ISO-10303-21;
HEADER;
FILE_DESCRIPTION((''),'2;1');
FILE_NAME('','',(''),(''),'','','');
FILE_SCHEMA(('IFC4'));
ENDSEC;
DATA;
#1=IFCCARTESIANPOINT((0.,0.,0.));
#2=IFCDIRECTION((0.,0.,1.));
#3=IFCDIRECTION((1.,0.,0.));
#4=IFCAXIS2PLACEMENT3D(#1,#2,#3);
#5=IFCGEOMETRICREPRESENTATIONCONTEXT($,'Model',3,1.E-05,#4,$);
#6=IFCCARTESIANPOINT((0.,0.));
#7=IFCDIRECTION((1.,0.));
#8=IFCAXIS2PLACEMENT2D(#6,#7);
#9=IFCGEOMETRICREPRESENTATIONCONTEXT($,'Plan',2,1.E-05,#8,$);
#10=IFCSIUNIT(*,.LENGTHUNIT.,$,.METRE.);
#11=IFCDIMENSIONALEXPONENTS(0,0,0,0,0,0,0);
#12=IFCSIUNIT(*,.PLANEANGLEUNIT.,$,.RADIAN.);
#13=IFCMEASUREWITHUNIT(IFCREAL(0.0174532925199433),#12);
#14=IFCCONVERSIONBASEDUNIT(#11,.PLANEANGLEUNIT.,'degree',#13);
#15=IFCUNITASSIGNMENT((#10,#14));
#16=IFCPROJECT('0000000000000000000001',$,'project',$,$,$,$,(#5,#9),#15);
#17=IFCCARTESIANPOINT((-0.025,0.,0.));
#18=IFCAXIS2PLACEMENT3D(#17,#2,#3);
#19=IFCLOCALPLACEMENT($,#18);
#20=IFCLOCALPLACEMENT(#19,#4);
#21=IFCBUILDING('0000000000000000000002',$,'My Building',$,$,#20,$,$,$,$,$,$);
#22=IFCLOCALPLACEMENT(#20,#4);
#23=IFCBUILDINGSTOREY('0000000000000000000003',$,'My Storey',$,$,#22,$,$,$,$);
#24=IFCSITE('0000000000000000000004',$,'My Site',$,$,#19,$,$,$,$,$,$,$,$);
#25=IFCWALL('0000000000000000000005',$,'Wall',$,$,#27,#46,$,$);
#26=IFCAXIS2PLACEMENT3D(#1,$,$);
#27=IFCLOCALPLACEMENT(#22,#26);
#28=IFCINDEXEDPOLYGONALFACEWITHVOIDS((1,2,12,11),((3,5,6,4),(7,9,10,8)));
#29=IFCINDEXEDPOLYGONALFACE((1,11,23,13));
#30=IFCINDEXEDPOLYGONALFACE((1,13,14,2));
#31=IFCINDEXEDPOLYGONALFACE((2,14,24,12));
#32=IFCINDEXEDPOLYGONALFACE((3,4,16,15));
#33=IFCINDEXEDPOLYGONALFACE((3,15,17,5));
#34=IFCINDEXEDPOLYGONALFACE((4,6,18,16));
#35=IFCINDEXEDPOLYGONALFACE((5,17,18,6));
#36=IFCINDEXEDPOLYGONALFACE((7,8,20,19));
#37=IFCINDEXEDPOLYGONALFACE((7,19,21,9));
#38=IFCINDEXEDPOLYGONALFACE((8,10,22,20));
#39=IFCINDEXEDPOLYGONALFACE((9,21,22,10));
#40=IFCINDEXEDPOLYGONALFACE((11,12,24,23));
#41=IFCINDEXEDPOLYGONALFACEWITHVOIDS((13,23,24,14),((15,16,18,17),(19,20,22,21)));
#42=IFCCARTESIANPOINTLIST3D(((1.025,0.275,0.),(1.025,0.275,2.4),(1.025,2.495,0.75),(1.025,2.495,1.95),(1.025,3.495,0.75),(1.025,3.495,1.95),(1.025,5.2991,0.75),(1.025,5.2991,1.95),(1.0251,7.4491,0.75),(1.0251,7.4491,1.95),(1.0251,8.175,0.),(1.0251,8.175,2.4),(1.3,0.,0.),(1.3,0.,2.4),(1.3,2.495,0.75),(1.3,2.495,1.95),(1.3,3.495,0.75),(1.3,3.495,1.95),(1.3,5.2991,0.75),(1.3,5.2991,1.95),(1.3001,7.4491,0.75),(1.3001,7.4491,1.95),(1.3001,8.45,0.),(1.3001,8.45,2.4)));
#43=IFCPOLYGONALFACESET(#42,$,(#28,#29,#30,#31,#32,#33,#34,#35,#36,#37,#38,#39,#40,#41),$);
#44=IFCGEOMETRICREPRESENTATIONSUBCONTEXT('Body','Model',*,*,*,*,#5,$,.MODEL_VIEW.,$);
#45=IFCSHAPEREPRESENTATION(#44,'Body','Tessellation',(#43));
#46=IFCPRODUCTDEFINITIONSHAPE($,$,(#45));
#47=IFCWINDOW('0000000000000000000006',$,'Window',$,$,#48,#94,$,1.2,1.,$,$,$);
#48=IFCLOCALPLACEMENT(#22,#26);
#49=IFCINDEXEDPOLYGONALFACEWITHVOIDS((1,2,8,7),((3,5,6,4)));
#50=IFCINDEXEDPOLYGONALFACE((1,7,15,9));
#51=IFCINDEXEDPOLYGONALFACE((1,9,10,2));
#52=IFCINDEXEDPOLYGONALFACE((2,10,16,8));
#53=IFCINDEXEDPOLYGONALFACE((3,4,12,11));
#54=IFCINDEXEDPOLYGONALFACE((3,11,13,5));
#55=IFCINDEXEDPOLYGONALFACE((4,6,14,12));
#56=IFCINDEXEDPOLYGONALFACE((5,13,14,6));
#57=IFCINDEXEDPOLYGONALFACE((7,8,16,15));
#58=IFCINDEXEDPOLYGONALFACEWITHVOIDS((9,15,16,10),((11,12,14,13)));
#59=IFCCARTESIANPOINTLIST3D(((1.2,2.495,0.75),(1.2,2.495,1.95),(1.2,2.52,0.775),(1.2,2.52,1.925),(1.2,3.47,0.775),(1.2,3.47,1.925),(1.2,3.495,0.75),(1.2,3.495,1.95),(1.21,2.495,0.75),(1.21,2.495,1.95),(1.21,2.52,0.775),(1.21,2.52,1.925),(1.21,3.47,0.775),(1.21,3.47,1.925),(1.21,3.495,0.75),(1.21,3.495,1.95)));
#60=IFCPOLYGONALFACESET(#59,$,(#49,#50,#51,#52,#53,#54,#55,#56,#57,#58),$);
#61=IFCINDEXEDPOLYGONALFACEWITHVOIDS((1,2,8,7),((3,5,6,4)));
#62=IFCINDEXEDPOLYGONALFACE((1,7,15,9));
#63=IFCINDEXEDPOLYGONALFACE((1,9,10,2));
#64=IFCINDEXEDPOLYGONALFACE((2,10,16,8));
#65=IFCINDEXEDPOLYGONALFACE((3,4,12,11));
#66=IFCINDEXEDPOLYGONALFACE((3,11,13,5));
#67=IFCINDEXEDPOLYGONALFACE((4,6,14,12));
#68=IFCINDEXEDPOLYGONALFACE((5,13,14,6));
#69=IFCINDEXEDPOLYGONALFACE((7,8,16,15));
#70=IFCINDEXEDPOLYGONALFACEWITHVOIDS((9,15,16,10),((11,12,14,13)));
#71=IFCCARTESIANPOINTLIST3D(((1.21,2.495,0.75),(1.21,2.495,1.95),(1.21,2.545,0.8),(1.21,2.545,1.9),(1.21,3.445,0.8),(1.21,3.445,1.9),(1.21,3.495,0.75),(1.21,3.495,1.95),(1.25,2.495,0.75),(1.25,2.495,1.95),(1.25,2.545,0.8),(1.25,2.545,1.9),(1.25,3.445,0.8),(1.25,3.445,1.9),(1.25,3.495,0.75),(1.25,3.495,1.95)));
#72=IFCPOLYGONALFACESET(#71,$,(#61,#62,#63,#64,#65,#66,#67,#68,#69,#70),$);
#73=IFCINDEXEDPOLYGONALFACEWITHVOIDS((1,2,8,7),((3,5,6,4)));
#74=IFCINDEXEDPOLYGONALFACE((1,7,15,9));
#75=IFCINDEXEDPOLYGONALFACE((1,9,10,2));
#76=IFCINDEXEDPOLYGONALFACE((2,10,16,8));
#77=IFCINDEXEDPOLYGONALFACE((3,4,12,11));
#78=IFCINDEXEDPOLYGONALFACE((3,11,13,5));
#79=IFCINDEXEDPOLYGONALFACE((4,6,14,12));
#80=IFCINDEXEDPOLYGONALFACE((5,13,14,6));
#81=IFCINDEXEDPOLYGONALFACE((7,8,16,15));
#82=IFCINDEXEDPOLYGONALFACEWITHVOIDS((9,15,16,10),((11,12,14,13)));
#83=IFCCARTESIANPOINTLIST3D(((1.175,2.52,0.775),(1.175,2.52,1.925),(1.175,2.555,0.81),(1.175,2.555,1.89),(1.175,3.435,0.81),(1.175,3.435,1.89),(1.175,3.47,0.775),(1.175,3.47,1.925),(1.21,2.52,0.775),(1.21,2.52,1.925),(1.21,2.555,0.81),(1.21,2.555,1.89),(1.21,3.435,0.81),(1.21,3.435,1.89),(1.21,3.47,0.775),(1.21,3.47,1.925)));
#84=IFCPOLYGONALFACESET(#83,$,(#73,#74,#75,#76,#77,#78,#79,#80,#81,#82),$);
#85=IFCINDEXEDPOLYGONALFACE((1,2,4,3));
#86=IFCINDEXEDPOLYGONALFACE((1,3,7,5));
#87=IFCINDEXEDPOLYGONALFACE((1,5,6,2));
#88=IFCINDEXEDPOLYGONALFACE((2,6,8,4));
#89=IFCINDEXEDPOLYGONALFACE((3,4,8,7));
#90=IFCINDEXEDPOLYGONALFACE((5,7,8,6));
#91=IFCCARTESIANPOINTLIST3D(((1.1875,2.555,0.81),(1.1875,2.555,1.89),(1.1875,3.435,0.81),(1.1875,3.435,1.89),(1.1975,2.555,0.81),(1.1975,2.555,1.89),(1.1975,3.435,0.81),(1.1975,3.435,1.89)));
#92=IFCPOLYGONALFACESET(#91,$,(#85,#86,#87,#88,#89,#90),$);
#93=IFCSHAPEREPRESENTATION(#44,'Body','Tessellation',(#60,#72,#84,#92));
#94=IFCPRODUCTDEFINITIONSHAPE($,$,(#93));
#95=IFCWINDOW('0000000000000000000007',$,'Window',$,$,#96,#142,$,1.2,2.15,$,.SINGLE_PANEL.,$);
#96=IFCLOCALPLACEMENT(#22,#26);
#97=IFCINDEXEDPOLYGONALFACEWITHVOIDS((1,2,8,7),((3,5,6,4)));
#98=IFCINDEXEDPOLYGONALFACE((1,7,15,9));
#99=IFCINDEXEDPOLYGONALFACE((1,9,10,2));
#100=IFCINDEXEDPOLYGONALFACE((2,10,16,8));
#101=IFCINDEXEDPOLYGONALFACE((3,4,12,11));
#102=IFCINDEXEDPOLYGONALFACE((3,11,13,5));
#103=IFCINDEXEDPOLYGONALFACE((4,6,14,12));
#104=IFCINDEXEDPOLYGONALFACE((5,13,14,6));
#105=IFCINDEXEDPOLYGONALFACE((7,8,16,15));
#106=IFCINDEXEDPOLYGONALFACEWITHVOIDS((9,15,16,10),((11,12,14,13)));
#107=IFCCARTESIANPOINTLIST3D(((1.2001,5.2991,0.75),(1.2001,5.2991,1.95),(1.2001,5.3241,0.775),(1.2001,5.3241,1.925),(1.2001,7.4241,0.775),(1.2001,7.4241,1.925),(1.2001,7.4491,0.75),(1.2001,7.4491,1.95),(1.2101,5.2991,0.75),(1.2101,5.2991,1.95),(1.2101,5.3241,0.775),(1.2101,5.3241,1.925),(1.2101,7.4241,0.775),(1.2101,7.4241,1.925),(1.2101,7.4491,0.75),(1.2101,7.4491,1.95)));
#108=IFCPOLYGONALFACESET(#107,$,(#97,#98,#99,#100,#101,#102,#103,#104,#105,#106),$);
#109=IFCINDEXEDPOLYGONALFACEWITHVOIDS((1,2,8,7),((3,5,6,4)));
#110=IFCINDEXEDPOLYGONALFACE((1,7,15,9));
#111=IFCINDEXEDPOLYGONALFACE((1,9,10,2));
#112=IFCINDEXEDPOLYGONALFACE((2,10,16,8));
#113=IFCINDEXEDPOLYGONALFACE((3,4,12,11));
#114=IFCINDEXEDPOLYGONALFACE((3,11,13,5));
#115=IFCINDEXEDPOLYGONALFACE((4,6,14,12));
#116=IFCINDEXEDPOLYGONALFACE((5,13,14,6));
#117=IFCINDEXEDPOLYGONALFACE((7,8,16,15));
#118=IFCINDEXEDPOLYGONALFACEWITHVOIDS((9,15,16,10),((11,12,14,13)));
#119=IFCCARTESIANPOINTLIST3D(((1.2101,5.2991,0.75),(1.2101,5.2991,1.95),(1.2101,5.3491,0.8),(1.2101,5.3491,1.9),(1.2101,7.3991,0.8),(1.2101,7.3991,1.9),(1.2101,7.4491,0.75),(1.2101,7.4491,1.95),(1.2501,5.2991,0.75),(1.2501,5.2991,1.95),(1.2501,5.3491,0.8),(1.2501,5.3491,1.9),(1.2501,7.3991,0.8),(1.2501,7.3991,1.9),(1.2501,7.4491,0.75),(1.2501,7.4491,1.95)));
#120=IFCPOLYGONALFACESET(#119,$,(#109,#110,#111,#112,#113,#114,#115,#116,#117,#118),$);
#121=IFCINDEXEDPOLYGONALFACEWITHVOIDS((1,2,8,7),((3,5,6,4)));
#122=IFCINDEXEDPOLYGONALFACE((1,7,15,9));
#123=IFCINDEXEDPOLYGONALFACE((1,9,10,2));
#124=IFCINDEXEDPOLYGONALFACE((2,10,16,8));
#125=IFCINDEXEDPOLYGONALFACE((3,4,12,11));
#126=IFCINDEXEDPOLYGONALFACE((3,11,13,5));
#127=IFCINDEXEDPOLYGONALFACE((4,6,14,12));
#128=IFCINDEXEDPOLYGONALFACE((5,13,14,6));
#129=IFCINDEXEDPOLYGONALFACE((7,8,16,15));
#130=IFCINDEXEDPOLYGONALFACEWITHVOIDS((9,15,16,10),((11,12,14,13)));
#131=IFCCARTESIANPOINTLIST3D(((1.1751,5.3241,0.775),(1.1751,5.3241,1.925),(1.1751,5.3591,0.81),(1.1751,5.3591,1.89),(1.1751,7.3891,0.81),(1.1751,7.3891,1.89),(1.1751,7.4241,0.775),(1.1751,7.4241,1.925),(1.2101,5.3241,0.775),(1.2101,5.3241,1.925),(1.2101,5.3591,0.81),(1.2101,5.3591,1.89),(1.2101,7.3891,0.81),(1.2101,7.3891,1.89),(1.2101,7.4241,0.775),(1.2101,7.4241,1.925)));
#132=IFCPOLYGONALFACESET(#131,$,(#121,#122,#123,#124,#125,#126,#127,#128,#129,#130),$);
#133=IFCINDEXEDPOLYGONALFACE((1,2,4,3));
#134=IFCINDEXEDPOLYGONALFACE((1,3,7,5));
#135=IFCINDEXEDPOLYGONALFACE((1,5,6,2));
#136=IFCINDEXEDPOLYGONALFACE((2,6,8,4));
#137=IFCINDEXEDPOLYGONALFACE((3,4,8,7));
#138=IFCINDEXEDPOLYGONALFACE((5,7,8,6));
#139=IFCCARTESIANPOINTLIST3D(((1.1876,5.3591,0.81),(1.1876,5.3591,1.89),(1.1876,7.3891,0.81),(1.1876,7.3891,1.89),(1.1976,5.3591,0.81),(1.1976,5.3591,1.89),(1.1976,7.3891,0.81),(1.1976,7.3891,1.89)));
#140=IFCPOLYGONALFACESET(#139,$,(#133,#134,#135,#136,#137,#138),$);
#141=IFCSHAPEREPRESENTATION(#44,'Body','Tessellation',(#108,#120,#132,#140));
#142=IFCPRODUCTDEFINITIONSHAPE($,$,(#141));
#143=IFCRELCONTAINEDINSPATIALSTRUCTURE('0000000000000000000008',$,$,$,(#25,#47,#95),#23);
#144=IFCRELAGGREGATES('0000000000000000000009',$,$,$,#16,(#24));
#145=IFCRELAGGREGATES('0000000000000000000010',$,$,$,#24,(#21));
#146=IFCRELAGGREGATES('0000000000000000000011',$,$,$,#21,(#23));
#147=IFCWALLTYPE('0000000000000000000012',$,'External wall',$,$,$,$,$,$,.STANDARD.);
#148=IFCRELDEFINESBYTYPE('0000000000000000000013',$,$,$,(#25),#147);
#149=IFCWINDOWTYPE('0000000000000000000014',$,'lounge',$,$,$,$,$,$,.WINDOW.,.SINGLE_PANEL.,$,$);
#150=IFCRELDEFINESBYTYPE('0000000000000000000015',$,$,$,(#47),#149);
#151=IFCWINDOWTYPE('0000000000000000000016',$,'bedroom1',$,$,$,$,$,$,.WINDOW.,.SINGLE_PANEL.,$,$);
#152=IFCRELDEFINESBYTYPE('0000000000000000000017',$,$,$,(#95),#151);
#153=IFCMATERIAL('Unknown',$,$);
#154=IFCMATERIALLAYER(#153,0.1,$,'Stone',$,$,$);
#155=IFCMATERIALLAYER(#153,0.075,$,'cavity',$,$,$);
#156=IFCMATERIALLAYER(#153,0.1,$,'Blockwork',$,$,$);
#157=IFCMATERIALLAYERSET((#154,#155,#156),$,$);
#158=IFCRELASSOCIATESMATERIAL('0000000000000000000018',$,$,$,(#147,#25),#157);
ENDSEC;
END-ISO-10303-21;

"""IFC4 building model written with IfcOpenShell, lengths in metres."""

from ifc_helpers import new_model, entity, si_unit, converted_unit, frame, origin_with_axes, origin_2d_with_axis, place, context, subcontext, project, spatial, line, indexed_curve, outline, extrude, clip, halfspace, shape, source, transform, mapped, material, layer, layer_set, layer_usage, type_object, type_shapes, element, fill, save


model = new_model("IFC4")

# Units and contexts
model_context = context("Model", 3, precision=1e-05, world=origin_with_axes())
plan_context = context("Plan", 2, precision=1e-05, world=origin_2d_with_axis())
body_context_1 = subcontext(model_context, "Body", "Model", "MODEL_VIEW")
body_context_2 = subcontext(plan_context, "Body", "Plan", "PLAN_VIEW")
ifc_project = project(units=[si_unit("LENGTHUNIT", "METRE"), converted_unit("PLANEANGLEUNIT", "degree", entity("IfcReal", 0.0174532925199433), si_unit("PLANEANGLEUNIT", "RADIAN"), dimensions=[0, 0, 0, 0, 0, 0, 0])], contexts=[model_context, plan_context])

# Site, building, storey
site_placement = place(None, frame((-0.025, 0.0, 0.0), z_axis=(0.0, 0.0, 1.0), x_axis=(1.0, 0.0, 0.0)))
site = spatial("IfcSite", under=ifc_project, at=site_placement, Name="My Site")
building_placement = place(site_placement, origin_with_axes())
building = spatial("IfcBuilding", under=site, at=building_placement, Name="My Building")
storey_placement = place(building_placement, origin_with_axes())
storey = spatial("IfcBuildingStorey", under=building, at=storey_placement, Name="My Storey")

# Shared definitions
ifc_material = material(Name="Unknown")
ifc_layer_1 = layer(ifc_material, 0.1, Name="Stone")
ifc_layer_2 = layer(ifc_material, 0.075, Name="cavity")
ifc_layer_3 = layer(ifc_material, 0.1, Name="Blockwork")
ifc_layer_set_1 = layer_set([ifc_layer_1, ifc_layer_2, ifc_layer_3])
wall_type_1 = type_object("IfcWallType", Name="External wall", PredefinedType="STANDARD", material=ifc_layer_set_1)

# Wall, openings, windows
ifc_layer_usage_1 = layer_usage(ifc_layer_set_1, "AXIS2", "POSITIVE", 0.0)
wall_1_placement = place(storey_placement, frame((1.3, 0.0, 0.0), z_axis=(0.0, 0.0, 1.0), x_axis=(0.0, 1.0, 0.0)))
wall_1 = element("IfcWall", 1, at=wall_1_placement, inside=storey, type_object=wall_type_1, material=ifc_layer_usage_1, Name="Wall", context=body_context_1, shape_type="Clipping", body=[
    clip(clip(extrude(outline(indexed_curve([(0.0, 0.0), (0.0, 0.275), (8.45, 0.275), (8.45, 0.0), (0.0, 0.0)], self_intersect=False)), origin_with_axes(), (0.0, 0.0, 1.0), 2.4), halfspace(frame((0.0, 0.0, 0.0), z_axis=(-0.707107, 0.707107, 0.0), x_axis=(0.707107, 0.707107, 0.0)), False)), halfspace(frame((8.45, 0.0, 0.0), z_axis=(0.707107, 0.707106, 0.0), x_axis=(-0.707106, 0.707107, 0.0)), False)),
])
shared_shape_1 = source(origin_with_axes(), body_context_1, "Body", "SweptSolid", [
    extrude(outline(indexed_curve([(0.0, 0.0), (1.0, 0.0), (1.0, 1.2), (0.0, 1.2)], segments=[line(1, 2, 3, 4, 1)])), frame((0.0, -0.6, 0.0), z_axis=(0.0, -1.0, 0.0), x_axis=(1.0, 0.0, 0.0)), (0.0, 0.0, -1.0), 1.2),
])
opening_1_placement = place(wall_1_placement, frame((2.495, 0.0, 0.75), z_axis=(0.0, 0.0, 1.0), x_axis=(1.0, 0.0, 0.0)))
opening_1 = element("IfcOpeningElement", 2, at=opening_1_placement, cuts=wall_1, PredefinedType="OPENING", context=body_context_1, shape_type="MappedRepresentation", body=[
    mapped(shared_shape_1, transform((0.0, 0.0, 0.0), x_axis=(1.0, 0.0, 0.0), y_axis=(0.0, 1.0, 0.0), z_axis=(0.0, 0.0, 1.0), scale=1.0)),
])
shared_shape_2 = source(origin_with_axes(), body_context_1, "Body", "SweptSolid", [
    extrude(outline(indexed_curve([(0.0, 0.0), (2.15, 0.0), (2.15, 1.2), (0.0, 1.2)], segments=[line(1, 2, 3, 4, 1)])), frame((0.0, -0.1, 0.0), z_axis=(0.0, -1.0, 0.0), x_axis=(1.0, 0.0, 0.0)), (0.0, 0.0, -1.0), 0.475),
])
opening_2_placement = place(wall_1_placement, frame((5.2991, 0.0, 0.75), z_axis=(0.0, 0.0, 1.0), x_axis=(1.0, 0.0, 0.0)))
opening_2 = element("IfcOpeningElement", 3, at=opening_2_placement, cuts=wall_1, PredefinedType="OPENING", context=body_context_1, shape_type="MappedRepresentation", body=[
    mapped(shared_shape_2, transform((0.0, 0.0, 0.0), x_axis=(1.0, 0.0, 0.0), y_axis=(0.0, 1.0, 0.0), z_axis=(0.0, 0.0, 1.0), scale=1.0)),
])
window_type_1 = type_object("IfcWindowType", Name="lounge", PartitioningType="SINGLE_PANEL", PredefinedType="WINDOW")
shared_shape_3 = source(origin_with_axes(), body_context_1, "Body", "SweptSolid", [
    extrude(outline(indexed_curve([(0.0, 0.0), (1.0, 0.0), (1.0, 1.2), (0.0, 1.2)], segments=[line(1, 2, 3, 4, 1)]), holes=[indexed_curve([(0.025, 0.025), (0.975, 0.025), (0.975, 1.175), (0.025, 1.175)], segments=[line(1, 2, 3, 4, 1)])]), frame((0.0, 0.09, 0.0), z_axis=(0.0, -1.0, 0.0), x_axis=(1.0, 0.0, 0.0)), (0.0, 0.0, -1.0), 0.01),
    extrude(outline(indexed_curve([(0.0, 0.0), (1.0, 0.0), (1.0, 1.2), (0.0, 1.2)], segments=[line(1, 2, 3, 4, 1)]), holes=[indexed_curve([(0.05, 0.05), (0.95, 0.05), (0.95, 1.15), (0.05, 1.15)], segments=[line(1, 2, 3, 4, 1)])]), frame((0.0, 0.05, 0.0), z_axis=(0.0, -1.0, 0.0), x_axis=(1.0, 0.0, 0.0)), (0.0, 0.0, -1.0), 0.04),
    extrude(outline(indexed_curve([(0.0, 0.0), (0.95, 0.0), (0.95, 1.15), (0.0, 1.15)], segments=[line(1, 2, 3, 4, 1)]), holes=[indexed_curve([(0.035, 0.035), (0.915, 0.035), (0.915, 1.115), (0.035, 1.115)], segments=[line(1, 2, 3, 4, 1)])]), frame((0.025, 0.09, 0.025), z_axis=(0.0, -1.0, 0.0), x_axis=(1.0, 0.0, 0.0)), (0.0, 0.0, -1.0), 0.035),
    extrude(outline(indexed_curve([(0.035, 0.035), (0.915, 0.035), (0.915, 1.115), (0.035, 1.115)], segments=[line(1, 2, 3, 4, 1)])), frame((0.025, 0.1025, 0.025), z_axis=(0.0, -1.0, 0.0), x_axis=(1.0, 0.0, 0.0)), (0.0, 0.0, -1.0), 0.01),
])
shared_shape_4 = source(origin_with_axes(), body_context_2, "Body", "Curve2D", [
    entity("IfcIndexedPolyCurve", entity("IfcCartesianPointList2D", [[0.05, 0.05], [0.95, 0.05]])),
    entity("IfcIndexedPolyCurve", entity("IfcCartesianPointList2D", [[0.0, 0.1], [0.025, 0.1], [0.025, 0.09], [0.05, 0.09], [0.05, 0.05], [0.0, 0.05]]), [entity("IfcLineIndex", [1, 2, 3, 4, 5, 6, 1])]),
    entity("IfcIndexedPolyCurve", entity("IfcCartesianPointList2D", [[1.0, 0.1], [0.975, 0.1], [0.975, 0.09], [0.95, 0.09], [0.95, 0.05], [1.0, 0.05]]), [entity("IfcLineIndex", [1, 2, 3, 4, 5, 6, 1])]),
    entity("IfcIndexedPolyCurve", entity("IfcCartesianPointList2D", [[0.025, 0.09], [0.06, 0.09], [0.06, 0.125], [0.025, 0.125]]), [entity("IfcLineIndex", [1, 2, 3, 4, 1])]),
    entity("IfcIndexedPolyCurve", entity("IfcCartesianPointList2D", [[0.975, 0.09], [0.94, 0.09], [0.94, 0.125], [0.975, 0.125]]), [entity("IfcLineIndex", [1, 2, 3, 4, 1])]),
    entity("IfcIndexedPolyCurve", entity("IfcCartesianPointList2D", [[0.06, 0.09], [0.94, 0.09]])),
    entity("IfcIndexedPolyCurve", entity("IfcCartesianPointList2D", [[0.06, 0.125], [0.94, 0.125]])),
    entity("IfcIndexedPolyCurve", entity("IfcCartesianPointList2D", [[0.06, 0.1075], [0.94, 0.1075]])),
])
type_shapes(window_type_1, [shared_shape_3, shared_shape_4])
window_1_placement = place(opening_1_placement, frame((0.0, 0.0, 0.0), z_axis=(0.0, 0.0, 1.0), x_axis=(1.0, 0.0, 0.0)))
window_1 = element("IfcWindow", 4, at=window_1_placement, inside=storey, type_object=window_type_1, Name="Window", OverallHeight=1.2, OverallWidth=1.0, shapes=[
    shape(body_context_1, "Body", "MappedRepresentation", [mapped(shared_shape_3, transform((0.0, 0.0, 0.0), x_axis=(1.0, 0.0, 0.0), y_axis=(0.0, 1.0, 0.0), z_axis=(0.0, 0.0, 1.0), scale=1.0))]),
    shape(body_context_2, "Body", "MappedRepresentation", [mapped(shared_shape_4, transform((0.0, 0.0, 0.0), x_axis=(1.0, 0.0, 0.0), y_axis=(0.0, 1.0, 0.0), z_axis=(0.0, 0.0, 1.0), scale=1.0))]),
])
fill(opening_1, window_1)
window_type_2 = type_object("IfcWindowType", Name="bedroom1", PartitioningType="SINGLE_PANEL", PredefinedType="WINDOW")
shared_shape_5 = source(origin_with_axes(), body_context_1, "Body", "SweptSolid", [
    extrude(outline(indexed_curve([(0.0, 0.0), (2.15, 0.0), (2.15, 1.2), (0.0, 1.2)], segments=[line(1, 2, 3, 4, 1)]), holes=[indexed_curve([(0.025, 0.025), (2.125, 0.025), (2.125, 1.175), (0.025, 1.175)], segments=[line(1, 2, 3, 4, 1)])]), frame((0.0, 0.09, 0.0), z_axis=(0.0, -1.0, 0.0), x_axis=(1.0, 0.0, 0.0)), (0.0, 0.0, -1.0), 0.01),
    extrude(outline(indexed_curve([(0.0, 0.0), (2.15, 0.0), (2.15, 1.2), (0.0, 1.2)], segments=[line(1, 2, 3, 4, 1)]), holes=[indexed_curve([(0.05, 0.05), (2.1, 0.05), (2.1, 1.15), (0.05, 1.15)], segments=[line(1, 2, 3, 4, 1)])]), frame((0.0, 0.05, 0.0), z_axis=(0.0, -1.0, 0.0), x_axis=(1.0, 0.0, 0.0)), (0.0, 0.0, -1.0), 0.04),
    extrude(outline(indexed_curve([(0.0, 0.0), (2.1, 0.0), (2.1, 1.15), (0.0, 1.15)], segments=[line(1, 2, 3, 4, 1)]), holes=[indexed_curve([(0.035, 0.035), (2.065, 0.035), (2.065, 1.115), (0.035, 1.115)], segments=[line(1, 2, 3, 4, 1)])]), frame((0.025, 0.09, 0.025), z_axis=(0.0, -1.0, 0.0), x_axis=(1.0, 0.0, 0.0)), (0.0, 0.0, -1.0), 0.035),
    extrude(outline(indexed_curve([(0.035, 0.035), (2.065, 0.035), (2.065, 1.115), (0.035, 1.115)], segments=[line(1, 2, 3, 4, 1)])), frame((0.025, 0.1025, 0.025), z_axis=(0.0, -1.0, 0.0), x_axis=(1.0, 0.0, 0.0)), (0.0, 0.0, -1.0), 0.01),
])
shared_shape_6 = source(origin_with_axes(), body_context_2, "Body", "Curve2D", [
    entity("IfcIndexedPolyCurve", entity("IfcCartesianPointList2D", [[0.05, 0.05], [2.1, 0.05]])),
    entity("IfcIndexedPolyCurve", entity("IfcCartesianPointList2D", [[0.0, 0.1], [0.025, 0.1], [0.025, 0.09], [0.05, 0.09], [0.05, 0.05], [0.0, 0.05]]), [entity("IfcLineIndex", [1, 2, 3, 4, 5, 6, 1])]),
    entity("IfcIndexedPolyCurve", entity("IfcCartesianPointList2D", [[2.15, 0.1], [2.125, 0.1], [2.125, 0.09], [2.1, 0.09], [2.1, 0.05], [2.15, 0.05]]), [entity("IfcLineIndex", [1, 2, 3, 4, 5, 6, 1])]),
    entity("IfcIndexedPolyCurve", entity("IfcCartesianPointList2D", [[0.025, 0.09], [0.06, 0.09], [0.06, 0.125], [0.025, 0.125]]), [entity("IfcLineIndex", [1, 2, 3, 4, 1])]),
    entity("IfcIndexedPolyCurve", entity("IfcCartesianPointList2D", [[2.125, 0.09], [2.09, 0.09], [2.09, 0.125], [2.125, 0.125]]), [entity("IfcLineIndex", [1, 2, 3, 4, 1])]),
    entity("IfcIndexedPolyCurve", entity("IfcCartesianPointList2D", [[0.06, 0.09], [2.09, 0.09]])),
    entity("IfcIndexedPolyCurve", entity("IfcCartesianPointList2D", [[0.06, 0.125], [2.09, 0.125]])),
    entity("IfcIndexedPolyCurve", entity("IfcCartesianPointList2D", [[0.06, 0.1075], [2.09, 0.1075]])),
])
type_shapes(window_type_2, [shared_shape_5, shared_shape_6])
window_2_placement = place(opening_2_placement, frame((0.0, 0.0, 0.0), z_axis=(0.0, 0.0, 1.0), x_axis=(1.0, 0.0, 0.0)))
window_2 = element("IfcWindow", 5, at=window_2_placement, inside=storey, type_object=window_type_2, Name="Window", OverallHeight=1.2, OverallWidth=2.15, PartitioningType="SINGLE_PANEL", shapes=[
    shape(body_context_1, "Body", "MappedRepresentation", [mapped(shared_shape_5, transform((0.0, 0.0, 0.0), x_axis=(1.0, 0.0, 0.0), y_axis=(0.0, 1.0, 0.0), z_axis=(0.0, 0.0, 1.0), scale=1.0))]),
    shape(body_context_2, "Body", "MappedRepresentation", [mapped(shared_shape_6, transform((0.0, 0.0, 0.0), x_axis=(1.0, 0.0, 0.0), y_axis=(0.0, 1.0, 0.0), z_axis=(0.0, 0.0, 1.0), scale=1.0))]),
])
fill(opening_2, window_2)

save(model, "model.ifc")
